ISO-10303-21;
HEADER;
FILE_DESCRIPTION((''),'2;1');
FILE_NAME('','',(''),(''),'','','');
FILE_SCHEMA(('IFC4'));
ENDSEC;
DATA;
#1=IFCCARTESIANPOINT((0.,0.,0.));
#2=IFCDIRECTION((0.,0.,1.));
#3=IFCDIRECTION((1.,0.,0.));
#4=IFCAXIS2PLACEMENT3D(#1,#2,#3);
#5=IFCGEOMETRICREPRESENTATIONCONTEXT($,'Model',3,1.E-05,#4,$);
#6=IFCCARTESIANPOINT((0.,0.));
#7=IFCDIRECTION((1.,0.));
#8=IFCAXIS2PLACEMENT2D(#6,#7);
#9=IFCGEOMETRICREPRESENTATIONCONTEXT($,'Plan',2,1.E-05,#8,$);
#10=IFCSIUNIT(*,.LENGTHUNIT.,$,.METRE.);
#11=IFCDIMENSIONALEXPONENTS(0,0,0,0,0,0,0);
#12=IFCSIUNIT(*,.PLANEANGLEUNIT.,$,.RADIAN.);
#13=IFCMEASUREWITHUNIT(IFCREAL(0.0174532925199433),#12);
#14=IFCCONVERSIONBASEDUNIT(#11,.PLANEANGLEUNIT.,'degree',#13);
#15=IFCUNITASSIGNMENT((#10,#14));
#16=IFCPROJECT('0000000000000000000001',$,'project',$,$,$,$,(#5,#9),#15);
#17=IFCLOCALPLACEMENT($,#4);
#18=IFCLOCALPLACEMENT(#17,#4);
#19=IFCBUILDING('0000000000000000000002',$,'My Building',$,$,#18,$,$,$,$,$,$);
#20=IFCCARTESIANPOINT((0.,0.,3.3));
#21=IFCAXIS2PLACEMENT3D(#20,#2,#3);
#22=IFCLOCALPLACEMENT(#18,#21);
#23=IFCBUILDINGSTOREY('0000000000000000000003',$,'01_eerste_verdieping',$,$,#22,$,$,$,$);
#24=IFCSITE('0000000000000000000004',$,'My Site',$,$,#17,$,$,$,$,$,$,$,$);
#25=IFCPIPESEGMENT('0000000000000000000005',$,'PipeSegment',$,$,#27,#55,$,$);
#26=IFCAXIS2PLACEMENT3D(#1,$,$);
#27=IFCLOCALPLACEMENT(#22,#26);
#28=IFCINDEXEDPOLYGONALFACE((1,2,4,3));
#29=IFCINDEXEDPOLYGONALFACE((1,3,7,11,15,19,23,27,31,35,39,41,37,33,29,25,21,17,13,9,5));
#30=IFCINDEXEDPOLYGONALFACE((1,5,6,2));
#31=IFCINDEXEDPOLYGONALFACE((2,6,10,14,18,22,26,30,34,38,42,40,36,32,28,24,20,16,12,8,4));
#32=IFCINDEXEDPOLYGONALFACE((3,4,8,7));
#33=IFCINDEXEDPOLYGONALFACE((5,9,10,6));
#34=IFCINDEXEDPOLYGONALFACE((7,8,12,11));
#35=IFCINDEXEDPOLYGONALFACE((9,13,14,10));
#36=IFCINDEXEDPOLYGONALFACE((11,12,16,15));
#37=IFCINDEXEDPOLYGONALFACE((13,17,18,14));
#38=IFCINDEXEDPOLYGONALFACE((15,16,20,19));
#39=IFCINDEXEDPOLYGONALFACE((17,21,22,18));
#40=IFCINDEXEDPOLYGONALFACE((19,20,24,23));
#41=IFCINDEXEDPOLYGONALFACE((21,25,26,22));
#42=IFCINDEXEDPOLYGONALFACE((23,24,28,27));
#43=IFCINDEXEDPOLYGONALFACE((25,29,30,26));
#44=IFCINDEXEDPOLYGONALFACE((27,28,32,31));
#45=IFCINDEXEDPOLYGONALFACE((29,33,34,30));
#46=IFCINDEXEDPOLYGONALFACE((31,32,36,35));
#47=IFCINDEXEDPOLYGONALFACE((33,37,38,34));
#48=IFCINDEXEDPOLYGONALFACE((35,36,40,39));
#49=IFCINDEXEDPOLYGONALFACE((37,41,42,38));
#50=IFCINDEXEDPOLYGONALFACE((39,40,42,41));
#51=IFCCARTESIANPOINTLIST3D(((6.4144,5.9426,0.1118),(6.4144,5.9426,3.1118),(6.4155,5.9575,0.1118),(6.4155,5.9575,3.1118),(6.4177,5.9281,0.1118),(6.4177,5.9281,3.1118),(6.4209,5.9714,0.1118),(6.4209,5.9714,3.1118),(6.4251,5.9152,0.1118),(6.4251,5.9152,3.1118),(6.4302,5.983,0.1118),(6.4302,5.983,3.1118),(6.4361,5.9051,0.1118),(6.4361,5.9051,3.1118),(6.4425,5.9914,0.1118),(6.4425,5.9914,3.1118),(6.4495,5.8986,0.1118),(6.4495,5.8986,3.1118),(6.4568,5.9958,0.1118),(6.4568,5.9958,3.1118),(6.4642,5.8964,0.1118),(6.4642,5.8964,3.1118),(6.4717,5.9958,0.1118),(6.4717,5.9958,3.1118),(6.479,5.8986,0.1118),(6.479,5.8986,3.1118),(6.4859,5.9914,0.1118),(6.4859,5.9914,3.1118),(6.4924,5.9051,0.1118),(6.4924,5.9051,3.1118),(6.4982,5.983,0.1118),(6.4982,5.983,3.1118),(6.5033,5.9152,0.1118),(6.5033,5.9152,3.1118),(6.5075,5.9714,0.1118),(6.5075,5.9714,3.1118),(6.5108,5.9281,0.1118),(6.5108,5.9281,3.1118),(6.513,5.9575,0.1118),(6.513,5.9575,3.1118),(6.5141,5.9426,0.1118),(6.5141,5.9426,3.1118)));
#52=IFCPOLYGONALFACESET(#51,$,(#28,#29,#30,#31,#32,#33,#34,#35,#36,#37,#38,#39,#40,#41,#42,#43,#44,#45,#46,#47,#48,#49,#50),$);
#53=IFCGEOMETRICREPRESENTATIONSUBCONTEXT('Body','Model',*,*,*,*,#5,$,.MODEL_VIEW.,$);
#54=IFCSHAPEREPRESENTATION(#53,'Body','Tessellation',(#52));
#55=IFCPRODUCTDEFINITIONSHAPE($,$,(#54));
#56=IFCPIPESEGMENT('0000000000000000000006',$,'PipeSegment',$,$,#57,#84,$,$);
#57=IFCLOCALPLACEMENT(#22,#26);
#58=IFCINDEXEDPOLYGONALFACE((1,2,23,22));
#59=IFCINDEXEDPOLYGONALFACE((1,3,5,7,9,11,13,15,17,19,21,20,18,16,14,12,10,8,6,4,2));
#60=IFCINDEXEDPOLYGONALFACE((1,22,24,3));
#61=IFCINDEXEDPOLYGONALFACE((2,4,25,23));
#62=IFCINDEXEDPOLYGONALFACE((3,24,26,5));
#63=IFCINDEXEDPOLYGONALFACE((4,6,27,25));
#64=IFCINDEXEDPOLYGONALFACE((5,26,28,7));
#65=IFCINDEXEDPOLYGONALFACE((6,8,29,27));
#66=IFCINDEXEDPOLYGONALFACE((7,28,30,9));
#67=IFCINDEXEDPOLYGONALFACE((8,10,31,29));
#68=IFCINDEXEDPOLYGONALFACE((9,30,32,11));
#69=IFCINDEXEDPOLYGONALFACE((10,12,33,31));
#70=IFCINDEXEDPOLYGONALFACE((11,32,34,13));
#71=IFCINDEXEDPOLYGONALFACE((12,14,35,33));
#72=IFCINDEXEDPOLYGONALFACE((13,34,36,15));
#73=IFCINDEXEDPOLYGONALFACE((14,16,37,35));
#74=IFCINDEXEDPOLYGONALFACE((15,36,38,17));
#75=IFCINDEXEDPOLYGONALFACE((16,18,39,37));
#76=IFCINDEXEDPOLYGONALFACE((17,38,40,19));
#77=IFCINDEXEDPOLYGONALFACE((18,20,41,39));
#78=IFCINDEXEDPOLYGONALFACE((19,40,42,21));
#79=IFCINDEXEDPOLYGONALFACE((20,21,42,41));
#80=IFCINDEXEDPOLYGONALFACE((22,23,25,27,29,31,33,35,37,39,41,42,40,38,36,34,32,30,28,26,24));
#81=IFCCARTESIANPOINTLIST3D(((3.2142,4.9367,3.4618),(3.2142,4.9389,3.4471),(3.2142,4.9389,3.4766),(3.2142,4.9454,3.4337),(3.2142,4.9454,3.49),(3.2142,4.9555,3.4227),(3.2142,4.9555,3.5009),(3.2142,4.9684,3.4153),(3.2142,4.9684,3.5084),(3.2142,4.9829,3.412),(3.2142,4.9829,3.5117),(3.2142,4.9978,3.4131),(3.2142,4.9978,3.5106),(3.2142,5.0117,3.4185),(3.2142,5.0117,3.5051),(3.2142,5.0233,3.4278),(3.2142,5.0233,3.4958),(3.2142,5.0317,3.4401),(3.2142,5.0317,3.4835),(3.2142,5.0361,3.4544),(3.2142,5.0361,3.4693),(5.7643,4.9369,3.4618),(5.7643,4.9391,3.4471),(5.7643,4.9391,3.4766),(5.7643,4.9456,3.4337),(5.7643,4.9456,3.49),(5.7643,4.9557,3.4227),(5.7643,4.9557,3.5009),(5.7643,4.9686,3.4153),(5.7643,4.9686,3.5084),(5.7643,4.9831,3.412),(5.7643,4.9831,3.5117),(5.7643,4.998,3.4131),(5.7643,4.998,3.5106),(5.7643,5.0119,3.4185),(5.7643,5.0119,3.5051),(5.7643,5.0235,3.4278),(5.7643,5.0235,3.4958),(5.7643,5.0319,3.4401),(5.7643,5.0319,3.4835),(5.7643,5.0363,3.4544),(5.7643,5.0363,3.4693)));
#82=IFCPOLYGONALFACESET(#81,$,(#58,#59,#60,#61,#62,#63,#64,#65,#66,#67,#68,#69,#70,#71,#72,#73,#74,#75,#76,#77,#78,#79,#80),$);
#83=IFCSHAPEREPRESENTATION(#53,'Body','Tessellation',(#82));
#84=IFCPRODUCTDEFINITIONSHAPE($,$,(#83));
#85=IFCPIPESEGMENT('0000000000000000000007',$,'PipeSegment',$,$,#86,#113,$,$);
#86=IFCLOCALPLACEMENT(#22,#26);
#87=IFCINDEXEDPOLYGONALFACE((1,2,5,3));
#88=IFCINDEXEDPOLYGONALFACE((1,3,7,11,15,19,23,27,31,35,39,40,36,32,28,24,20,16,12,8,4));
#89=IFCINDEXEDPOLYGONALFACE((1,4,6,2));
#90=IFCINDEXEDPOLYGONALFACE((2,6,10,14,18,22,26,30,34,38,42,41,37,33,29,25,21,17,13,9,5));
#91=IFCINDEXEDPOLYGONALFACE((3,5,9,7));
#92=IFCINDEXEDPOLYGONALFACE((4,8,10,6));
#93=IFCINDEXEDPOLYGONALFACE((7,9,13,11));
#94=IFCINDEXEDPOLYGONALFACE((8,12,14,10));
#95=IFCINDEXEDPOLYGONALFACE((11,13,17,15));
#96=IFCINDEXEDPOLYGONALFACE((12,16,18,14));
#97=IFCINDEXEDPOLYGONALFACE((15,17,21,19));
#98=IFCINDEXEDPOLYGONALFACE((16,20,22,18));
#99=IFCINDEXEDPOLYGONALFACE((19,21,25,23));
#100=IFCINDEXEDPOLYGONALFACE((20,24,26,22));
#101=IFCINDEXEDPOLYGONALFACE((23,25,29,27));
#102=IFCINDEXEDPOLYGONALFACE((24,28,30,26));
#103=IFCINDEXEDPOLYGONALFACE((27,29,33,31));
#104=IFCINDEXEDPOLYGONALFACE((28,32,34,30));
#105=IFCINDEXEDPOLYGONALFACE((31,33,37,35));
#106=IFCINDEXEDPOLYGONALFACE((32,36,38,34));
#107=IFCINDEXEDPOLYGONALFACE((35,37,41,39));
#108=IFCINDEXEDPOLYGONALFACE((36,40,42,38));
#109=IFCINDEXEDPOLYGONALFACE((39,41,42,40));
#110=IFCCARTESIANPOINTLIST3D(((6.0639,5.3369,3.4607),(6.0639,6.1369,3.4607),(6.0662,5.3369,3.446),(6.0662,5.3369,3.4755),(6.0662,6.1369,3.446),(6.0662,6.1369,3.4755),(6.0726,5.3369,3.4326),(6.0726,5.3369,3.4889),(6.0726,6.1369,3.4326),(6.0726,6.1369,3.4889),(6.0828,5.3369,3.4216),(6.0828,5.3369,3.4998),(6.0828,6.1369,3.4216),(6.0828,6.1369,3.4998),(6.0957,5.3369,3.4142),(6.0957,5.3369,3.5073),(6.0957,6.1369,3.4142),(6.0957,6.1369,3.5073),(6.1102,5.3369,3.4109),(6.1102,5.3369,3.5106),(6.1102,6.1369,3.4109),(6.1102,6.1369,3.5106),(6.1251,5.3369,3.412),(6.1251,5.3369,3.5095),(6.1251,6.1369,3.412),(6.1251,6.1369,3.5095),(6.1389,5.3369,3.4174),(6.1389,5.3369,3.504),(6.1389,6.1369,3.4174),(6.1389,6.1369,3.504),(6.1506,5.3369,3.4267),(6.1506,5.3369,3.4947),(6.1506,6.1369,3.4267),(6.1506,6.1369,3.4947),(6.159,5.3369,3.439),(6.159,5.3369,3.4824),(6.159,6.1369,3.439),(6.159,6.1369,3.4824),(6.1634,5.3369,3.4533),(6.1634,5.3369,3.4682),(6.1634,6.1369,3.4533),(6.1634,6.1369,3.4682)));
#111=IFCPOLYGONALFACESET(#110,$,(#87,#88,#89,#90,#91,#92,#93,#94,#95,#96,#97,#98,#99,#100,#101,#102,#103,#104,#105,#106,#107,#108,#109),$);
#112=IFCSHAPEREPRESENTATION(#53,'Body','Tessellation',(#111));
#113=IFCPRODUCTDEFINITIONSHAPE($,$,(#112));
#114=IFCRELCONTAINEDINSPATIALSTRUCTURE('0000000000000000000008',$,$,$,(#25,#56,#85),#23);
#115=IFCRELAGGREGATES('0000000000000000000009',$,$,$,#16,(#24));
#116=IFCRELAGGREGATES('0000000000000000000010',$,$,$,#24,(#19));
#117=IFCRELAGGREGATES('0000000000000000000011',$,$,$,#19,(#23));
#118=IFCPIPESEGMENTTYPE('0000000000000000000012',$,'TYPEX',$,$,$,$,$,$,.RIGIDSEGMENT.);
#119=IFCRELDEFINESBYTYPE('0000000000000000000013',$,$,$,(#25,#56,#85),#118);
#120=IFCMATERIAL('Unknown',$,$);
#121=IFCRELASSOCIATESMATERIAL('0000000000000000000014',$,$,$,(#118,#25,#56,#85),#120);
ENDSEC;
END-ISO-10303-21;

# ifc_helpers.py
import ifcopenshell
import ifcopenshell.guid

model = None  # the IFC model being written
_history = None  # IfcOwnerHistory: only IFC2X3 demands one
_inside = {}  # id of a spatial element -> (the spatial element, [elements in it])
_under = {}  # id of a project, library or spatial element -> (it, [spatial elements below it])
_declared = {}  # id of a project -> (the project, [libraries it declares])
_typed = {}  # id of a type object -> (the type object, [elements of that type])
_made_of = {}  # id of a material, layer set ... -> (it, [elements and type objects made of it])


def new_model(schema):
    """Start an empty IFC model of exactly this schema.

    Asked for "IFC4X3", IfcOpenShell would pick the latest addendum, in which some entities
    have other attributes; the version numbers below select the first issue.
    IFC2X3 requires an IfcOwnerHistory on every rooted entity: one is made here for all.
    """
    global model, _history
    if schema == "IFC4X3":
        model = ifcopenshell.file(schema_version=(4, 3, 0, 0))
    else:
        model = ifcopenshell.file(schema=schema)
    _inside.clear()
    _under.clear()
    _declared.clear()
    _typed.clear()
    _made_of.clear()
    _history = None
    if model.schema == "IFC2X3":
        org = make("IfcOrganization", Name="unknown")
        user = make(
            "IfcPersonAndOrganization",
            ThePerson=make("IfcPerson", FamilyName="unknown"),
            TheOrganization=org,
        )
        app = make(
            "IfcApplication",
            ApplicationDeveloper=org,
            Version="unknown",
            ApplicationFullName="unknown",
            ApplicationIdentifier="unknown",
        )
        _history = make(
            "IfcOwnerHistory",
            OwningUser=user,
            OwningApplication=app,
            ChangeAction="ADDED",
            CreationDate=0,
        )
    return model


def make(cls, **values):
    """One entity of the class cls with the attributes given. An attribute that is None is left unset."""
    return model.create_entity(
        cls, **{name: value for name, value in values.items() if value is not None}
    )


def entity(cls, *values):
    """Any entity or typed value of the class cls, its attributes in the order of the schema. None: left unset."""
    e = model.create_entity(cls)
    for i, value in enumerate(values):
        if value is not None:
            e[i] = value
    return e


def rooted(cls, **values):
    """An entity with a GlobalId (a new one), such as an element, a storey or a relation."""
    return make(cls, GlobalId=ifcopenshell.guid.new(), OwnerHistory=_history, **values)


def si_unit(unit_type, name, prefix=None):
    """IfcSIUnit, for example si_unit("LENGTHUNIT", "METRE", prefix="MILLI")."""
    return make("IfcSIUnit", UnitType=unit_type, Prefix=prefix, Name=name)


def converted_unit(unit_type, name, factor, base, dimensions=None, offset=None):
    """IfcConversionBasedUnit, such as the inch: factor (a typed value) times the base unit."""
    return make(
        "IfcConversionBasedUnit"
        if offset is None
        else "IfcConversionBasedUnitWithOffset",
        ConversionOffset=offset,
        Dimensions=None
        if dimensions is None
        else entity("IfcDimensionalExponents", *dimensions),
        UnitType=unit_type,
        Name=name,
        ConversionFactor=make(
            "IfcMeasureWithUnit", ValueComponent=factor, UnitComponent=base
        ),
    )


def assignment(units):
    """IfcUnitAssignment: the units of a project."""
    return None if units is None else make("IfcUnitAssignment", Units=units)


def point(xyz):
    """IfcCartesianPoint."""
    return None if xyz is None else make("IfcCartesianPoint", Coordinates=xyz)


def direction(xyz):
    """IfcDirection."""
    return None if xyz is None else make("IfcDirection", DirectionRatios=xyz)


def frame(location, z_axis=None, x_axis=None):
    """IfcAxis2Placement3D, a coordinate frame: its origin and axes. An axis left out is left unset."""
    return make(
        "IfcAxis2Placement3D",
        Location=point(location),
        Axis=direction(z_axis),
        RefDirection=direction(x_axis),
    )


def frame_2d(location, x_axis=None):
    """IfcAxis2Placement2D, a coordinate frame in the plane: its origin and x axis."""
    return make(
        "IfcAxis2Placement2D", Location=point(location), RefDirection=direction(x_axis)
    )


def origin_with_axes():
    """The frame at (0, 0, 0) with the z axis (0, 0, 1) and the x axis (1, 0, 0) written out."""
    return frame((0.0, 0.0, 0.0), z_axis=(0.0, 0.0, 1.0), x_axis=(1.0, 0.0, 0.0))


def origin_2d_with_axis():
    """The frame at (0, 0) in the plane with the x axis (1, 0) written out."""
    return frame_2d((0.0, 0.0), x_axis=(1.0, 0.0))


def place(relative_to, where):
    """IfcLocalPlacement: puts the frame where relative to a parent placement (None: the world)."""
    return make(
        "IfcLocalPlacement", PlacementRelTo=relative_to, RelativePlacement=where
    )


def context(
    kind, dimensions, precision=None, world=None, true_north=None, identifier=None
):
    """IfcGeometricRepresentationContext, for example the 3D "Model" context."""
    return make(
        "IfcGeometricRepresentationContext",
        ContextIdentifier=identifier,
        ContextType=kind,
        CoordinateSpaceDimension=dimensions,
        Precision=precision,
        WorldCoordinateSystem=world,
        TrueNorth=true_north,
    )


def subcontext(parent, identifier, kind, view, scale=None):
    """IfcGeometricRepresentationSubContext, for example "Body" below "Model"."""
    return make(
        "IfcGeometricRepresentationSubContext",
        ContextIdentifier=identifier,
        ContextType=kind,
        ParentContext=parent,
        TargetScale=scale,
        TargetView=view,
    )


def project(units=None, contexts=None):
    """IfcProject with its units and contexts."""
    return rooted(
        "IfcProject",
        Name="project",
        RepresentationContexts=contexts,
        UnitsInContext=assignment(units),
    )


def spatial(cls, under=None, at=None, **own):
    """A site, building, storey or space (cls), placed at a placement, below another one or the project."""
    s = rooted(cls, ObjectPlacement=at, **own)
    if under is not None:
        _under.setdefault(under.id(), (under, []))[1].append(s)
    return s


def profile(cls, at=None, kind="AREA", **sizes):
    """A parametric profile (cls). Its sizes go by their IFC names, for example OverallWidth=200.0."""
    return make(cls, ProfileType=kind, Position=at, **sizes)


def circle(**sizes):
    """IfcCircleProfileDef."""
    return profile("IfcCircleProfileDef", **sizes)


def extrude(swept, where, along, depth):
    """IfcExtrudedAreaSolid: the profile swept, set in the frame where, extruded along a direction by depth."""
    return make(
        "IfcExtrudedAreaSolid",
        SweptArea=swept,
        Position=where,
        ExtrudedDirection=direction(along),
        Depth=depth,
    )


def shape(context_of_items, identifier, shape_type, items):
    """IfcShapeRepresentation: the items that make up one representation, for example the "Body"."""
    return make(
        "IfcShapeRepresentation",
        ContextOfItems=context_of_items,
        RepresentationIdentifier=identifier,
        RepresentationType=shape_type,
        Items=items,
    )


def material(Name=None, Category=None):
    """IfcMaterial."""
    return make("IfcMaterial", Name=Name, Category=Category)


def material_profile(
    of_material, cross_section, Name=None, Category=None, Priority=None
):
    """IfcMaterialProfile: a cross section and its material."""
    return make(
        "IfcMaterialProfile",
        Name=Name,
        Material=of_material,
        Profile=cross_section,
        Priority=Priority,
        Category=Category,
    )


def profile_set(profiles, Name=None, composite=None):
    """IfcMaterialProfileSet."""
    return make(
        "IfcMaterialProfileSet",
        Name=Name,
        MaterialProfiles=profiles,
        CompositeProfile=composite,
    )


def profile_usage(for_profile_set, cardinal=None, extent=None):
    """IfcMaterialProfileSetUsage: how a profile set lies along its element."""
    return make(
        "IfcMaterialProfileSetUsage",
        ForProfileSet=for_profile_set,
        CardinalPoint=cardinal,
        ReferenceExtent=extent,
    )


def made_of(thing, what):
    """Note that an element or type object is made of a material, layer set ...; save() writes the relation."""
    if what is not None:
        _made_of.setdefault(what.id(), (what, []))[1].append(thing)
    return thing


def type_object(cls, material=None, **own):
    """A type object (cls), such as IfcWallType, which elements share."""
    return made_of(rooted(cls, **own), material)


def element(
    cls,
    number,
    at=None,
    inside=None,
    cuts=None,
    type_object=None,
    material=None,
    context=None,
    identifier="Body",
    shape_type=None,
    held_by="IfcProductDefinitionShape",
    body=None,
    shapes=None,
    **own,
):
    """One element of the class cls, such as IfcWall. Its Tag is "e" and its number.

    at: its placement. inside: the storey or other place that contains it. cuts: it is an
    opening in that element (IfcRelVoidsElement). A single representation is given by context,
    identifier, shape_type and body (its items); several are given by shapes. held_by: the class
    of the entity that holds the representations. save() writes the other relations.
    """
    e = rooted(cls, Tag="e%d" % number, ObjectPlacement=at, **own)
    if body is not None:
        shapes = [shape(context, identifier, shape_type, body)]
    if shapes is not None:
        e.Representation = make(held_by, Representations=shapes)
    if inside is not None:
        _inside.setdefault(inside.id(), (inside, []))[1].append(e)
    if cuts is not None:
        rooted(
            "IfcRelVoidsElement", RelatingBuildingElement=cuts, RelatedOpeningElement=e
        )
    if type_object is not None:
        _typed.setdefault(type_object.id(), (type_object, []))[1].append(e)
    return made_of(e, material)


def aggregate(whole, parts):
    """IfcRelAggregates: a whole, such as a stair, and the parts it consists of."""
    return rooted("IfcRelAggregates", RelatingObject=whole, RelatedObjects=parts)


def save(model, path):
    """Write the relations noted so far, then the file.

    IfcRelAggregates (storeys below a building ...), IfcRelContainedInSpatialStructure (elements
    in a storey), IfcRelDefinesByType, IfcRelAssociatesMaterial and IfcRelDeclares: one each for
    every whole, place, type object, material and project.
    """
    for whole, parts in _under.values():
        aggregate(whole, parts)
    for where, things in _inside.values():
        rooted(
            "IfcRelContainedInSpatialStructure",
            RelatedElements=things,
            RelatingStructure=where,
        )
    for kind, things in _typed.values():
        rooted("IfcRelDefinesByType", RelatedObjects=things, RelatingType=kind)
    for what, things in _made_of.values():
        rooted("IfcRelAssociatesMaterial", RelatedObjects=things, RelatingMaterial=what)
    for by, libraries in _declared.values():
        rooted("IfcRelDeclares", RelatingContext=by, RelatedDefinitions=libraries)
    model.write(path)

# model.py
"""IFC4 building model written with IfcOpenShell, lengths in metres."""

from ifc_helpers import new_model, entity, si_unit, converted_unit, frame, origin_with_axes, origin_2d_with_axis, place, context, subcontext, project, spatial, circle, extrude, material, material_profile, profile_set, profile_usage, type_object, element, save


model = new_model("IFC4")

# Units and contexts
model_context = context("Model", 3, precision=1e-05, world=origin_with_axes())
plan_context = context("Plan", 2, precision=1e-05, world=origin_2d_with_axis())
body_context_1 = subcontext(model_context, "Body", "Model", "MODEL_VIEW")
ifc_project = project(units=[si_unit("LENGTHUNIT", "METRE"), converted_unit("PLANEANGLEUNIT", "degree", entity("IfcReal", 0.0174532925199433), si_unit("PLANEANGLEUNIT", "RADIAN"), dimensions=[0, 0, 0, 0, 0, 0, 0])], contexts=[model_context, plan_context])

# Site, building, storey
site_placement = place(None, origin_with_axes())
site = spatial("IfcSite", under=ifc_project, at=site_placement, Name="My Site")
building_placement = place(site_placement, origin_with_axes())
building = spatial("IfcBuilding", under=site, at=building_placement, Name="My Building")
storey_placement = place(building_placement, frame((0.0, 0.0, 3.3), z_axis=(0.0, 0.0, 1.0), x_axis=(1.0, 0.0, 0.0)))
storey = spatial("IfcBuildingStorey", under=building, at=storey_placement, Name="01_eerste_verdieping")

# Shared definitions
ifc_material = material(Name="Unknown")

# Pipe segments
ifc_material_profile = material_profile(ifc_material, circle(Radius=0.05))
ifc_profile_set = profile_set([ifc_material_profile])
ifc_profile_usage_1 = profile_usage(ifc_profile_set, cardinal=5)
pipe_segment_type = type_object("IfcPipeSegmentType", Name="TYPEX", PredefinedType="RIGIDSEGMENT", material=ifc_profile_set)
pipe_segment_1_placement = place(storey_placement, frame((6.4642, 5.9464, 3.1118), z_axis=(0.0, 0.0, -1.0), x_axis=(0.000073, -1.0, 0.0)))
element("IfcPipeSegment", 1, at=pipe_segment_1_placement, inside=storey, type_object=pipe_segment_type, material=ifc_profile_usage_1, Name="PipeSegment", context=body_context_1, shape_type="SweptSolid", body=[
    extrude(circle(Radius=0.05), origin_with_axes(), (0.0, 0.0, 1.0), 3.0),
])
ifc_profile_usage_2 = profile_usage(ifc_profile_set, cardinal=5)
pipe_segment_2_placement = place(storey_placement, frame((5.7643, 4.9869, 3.4618), z_axis=(-1.0, -0.000073, 0.0), x_axis=(0.000073, -1.0, 0.0)))
element("IfcPipeSegment", 2, at=pipe_segment_2_placement, inside=storey, type_object=pipe_segment_type, material=ifc_profile_usage_2, Name="PipeSegment", context=body_context_1, shape_type="SweptSolid", body=[
    extrude(circle(Radius=0.05), origin_with_axes(), (0.0, 0.0, 1.0), 2.5501),
])
ifc_profile_usage_3 = profile_usage(ifc_profile_set, cardinal=5)
pipe_segment_3_placement = place(storey_placement, frame((6.1139, 5.3369, 3.4607), z_axis=(0.0, 1.0, 0.0), x_axis=(-1.0, 0.0, 0.0)))
element("IfcPipeSegment", 3, at=pipe_segment_3_placement, inside=storey, type_object=pipe_segment_type, material=ifc_profile_usage_3, Name="PipeSegment", context=body_context_1, shape_type="SweptSolid", body=[
    extrude(circle(Radius=0.05), origin_with_axes(), (0.0, 0.0, 1.0), 0.8),
])

save(model, "model.ifc")
